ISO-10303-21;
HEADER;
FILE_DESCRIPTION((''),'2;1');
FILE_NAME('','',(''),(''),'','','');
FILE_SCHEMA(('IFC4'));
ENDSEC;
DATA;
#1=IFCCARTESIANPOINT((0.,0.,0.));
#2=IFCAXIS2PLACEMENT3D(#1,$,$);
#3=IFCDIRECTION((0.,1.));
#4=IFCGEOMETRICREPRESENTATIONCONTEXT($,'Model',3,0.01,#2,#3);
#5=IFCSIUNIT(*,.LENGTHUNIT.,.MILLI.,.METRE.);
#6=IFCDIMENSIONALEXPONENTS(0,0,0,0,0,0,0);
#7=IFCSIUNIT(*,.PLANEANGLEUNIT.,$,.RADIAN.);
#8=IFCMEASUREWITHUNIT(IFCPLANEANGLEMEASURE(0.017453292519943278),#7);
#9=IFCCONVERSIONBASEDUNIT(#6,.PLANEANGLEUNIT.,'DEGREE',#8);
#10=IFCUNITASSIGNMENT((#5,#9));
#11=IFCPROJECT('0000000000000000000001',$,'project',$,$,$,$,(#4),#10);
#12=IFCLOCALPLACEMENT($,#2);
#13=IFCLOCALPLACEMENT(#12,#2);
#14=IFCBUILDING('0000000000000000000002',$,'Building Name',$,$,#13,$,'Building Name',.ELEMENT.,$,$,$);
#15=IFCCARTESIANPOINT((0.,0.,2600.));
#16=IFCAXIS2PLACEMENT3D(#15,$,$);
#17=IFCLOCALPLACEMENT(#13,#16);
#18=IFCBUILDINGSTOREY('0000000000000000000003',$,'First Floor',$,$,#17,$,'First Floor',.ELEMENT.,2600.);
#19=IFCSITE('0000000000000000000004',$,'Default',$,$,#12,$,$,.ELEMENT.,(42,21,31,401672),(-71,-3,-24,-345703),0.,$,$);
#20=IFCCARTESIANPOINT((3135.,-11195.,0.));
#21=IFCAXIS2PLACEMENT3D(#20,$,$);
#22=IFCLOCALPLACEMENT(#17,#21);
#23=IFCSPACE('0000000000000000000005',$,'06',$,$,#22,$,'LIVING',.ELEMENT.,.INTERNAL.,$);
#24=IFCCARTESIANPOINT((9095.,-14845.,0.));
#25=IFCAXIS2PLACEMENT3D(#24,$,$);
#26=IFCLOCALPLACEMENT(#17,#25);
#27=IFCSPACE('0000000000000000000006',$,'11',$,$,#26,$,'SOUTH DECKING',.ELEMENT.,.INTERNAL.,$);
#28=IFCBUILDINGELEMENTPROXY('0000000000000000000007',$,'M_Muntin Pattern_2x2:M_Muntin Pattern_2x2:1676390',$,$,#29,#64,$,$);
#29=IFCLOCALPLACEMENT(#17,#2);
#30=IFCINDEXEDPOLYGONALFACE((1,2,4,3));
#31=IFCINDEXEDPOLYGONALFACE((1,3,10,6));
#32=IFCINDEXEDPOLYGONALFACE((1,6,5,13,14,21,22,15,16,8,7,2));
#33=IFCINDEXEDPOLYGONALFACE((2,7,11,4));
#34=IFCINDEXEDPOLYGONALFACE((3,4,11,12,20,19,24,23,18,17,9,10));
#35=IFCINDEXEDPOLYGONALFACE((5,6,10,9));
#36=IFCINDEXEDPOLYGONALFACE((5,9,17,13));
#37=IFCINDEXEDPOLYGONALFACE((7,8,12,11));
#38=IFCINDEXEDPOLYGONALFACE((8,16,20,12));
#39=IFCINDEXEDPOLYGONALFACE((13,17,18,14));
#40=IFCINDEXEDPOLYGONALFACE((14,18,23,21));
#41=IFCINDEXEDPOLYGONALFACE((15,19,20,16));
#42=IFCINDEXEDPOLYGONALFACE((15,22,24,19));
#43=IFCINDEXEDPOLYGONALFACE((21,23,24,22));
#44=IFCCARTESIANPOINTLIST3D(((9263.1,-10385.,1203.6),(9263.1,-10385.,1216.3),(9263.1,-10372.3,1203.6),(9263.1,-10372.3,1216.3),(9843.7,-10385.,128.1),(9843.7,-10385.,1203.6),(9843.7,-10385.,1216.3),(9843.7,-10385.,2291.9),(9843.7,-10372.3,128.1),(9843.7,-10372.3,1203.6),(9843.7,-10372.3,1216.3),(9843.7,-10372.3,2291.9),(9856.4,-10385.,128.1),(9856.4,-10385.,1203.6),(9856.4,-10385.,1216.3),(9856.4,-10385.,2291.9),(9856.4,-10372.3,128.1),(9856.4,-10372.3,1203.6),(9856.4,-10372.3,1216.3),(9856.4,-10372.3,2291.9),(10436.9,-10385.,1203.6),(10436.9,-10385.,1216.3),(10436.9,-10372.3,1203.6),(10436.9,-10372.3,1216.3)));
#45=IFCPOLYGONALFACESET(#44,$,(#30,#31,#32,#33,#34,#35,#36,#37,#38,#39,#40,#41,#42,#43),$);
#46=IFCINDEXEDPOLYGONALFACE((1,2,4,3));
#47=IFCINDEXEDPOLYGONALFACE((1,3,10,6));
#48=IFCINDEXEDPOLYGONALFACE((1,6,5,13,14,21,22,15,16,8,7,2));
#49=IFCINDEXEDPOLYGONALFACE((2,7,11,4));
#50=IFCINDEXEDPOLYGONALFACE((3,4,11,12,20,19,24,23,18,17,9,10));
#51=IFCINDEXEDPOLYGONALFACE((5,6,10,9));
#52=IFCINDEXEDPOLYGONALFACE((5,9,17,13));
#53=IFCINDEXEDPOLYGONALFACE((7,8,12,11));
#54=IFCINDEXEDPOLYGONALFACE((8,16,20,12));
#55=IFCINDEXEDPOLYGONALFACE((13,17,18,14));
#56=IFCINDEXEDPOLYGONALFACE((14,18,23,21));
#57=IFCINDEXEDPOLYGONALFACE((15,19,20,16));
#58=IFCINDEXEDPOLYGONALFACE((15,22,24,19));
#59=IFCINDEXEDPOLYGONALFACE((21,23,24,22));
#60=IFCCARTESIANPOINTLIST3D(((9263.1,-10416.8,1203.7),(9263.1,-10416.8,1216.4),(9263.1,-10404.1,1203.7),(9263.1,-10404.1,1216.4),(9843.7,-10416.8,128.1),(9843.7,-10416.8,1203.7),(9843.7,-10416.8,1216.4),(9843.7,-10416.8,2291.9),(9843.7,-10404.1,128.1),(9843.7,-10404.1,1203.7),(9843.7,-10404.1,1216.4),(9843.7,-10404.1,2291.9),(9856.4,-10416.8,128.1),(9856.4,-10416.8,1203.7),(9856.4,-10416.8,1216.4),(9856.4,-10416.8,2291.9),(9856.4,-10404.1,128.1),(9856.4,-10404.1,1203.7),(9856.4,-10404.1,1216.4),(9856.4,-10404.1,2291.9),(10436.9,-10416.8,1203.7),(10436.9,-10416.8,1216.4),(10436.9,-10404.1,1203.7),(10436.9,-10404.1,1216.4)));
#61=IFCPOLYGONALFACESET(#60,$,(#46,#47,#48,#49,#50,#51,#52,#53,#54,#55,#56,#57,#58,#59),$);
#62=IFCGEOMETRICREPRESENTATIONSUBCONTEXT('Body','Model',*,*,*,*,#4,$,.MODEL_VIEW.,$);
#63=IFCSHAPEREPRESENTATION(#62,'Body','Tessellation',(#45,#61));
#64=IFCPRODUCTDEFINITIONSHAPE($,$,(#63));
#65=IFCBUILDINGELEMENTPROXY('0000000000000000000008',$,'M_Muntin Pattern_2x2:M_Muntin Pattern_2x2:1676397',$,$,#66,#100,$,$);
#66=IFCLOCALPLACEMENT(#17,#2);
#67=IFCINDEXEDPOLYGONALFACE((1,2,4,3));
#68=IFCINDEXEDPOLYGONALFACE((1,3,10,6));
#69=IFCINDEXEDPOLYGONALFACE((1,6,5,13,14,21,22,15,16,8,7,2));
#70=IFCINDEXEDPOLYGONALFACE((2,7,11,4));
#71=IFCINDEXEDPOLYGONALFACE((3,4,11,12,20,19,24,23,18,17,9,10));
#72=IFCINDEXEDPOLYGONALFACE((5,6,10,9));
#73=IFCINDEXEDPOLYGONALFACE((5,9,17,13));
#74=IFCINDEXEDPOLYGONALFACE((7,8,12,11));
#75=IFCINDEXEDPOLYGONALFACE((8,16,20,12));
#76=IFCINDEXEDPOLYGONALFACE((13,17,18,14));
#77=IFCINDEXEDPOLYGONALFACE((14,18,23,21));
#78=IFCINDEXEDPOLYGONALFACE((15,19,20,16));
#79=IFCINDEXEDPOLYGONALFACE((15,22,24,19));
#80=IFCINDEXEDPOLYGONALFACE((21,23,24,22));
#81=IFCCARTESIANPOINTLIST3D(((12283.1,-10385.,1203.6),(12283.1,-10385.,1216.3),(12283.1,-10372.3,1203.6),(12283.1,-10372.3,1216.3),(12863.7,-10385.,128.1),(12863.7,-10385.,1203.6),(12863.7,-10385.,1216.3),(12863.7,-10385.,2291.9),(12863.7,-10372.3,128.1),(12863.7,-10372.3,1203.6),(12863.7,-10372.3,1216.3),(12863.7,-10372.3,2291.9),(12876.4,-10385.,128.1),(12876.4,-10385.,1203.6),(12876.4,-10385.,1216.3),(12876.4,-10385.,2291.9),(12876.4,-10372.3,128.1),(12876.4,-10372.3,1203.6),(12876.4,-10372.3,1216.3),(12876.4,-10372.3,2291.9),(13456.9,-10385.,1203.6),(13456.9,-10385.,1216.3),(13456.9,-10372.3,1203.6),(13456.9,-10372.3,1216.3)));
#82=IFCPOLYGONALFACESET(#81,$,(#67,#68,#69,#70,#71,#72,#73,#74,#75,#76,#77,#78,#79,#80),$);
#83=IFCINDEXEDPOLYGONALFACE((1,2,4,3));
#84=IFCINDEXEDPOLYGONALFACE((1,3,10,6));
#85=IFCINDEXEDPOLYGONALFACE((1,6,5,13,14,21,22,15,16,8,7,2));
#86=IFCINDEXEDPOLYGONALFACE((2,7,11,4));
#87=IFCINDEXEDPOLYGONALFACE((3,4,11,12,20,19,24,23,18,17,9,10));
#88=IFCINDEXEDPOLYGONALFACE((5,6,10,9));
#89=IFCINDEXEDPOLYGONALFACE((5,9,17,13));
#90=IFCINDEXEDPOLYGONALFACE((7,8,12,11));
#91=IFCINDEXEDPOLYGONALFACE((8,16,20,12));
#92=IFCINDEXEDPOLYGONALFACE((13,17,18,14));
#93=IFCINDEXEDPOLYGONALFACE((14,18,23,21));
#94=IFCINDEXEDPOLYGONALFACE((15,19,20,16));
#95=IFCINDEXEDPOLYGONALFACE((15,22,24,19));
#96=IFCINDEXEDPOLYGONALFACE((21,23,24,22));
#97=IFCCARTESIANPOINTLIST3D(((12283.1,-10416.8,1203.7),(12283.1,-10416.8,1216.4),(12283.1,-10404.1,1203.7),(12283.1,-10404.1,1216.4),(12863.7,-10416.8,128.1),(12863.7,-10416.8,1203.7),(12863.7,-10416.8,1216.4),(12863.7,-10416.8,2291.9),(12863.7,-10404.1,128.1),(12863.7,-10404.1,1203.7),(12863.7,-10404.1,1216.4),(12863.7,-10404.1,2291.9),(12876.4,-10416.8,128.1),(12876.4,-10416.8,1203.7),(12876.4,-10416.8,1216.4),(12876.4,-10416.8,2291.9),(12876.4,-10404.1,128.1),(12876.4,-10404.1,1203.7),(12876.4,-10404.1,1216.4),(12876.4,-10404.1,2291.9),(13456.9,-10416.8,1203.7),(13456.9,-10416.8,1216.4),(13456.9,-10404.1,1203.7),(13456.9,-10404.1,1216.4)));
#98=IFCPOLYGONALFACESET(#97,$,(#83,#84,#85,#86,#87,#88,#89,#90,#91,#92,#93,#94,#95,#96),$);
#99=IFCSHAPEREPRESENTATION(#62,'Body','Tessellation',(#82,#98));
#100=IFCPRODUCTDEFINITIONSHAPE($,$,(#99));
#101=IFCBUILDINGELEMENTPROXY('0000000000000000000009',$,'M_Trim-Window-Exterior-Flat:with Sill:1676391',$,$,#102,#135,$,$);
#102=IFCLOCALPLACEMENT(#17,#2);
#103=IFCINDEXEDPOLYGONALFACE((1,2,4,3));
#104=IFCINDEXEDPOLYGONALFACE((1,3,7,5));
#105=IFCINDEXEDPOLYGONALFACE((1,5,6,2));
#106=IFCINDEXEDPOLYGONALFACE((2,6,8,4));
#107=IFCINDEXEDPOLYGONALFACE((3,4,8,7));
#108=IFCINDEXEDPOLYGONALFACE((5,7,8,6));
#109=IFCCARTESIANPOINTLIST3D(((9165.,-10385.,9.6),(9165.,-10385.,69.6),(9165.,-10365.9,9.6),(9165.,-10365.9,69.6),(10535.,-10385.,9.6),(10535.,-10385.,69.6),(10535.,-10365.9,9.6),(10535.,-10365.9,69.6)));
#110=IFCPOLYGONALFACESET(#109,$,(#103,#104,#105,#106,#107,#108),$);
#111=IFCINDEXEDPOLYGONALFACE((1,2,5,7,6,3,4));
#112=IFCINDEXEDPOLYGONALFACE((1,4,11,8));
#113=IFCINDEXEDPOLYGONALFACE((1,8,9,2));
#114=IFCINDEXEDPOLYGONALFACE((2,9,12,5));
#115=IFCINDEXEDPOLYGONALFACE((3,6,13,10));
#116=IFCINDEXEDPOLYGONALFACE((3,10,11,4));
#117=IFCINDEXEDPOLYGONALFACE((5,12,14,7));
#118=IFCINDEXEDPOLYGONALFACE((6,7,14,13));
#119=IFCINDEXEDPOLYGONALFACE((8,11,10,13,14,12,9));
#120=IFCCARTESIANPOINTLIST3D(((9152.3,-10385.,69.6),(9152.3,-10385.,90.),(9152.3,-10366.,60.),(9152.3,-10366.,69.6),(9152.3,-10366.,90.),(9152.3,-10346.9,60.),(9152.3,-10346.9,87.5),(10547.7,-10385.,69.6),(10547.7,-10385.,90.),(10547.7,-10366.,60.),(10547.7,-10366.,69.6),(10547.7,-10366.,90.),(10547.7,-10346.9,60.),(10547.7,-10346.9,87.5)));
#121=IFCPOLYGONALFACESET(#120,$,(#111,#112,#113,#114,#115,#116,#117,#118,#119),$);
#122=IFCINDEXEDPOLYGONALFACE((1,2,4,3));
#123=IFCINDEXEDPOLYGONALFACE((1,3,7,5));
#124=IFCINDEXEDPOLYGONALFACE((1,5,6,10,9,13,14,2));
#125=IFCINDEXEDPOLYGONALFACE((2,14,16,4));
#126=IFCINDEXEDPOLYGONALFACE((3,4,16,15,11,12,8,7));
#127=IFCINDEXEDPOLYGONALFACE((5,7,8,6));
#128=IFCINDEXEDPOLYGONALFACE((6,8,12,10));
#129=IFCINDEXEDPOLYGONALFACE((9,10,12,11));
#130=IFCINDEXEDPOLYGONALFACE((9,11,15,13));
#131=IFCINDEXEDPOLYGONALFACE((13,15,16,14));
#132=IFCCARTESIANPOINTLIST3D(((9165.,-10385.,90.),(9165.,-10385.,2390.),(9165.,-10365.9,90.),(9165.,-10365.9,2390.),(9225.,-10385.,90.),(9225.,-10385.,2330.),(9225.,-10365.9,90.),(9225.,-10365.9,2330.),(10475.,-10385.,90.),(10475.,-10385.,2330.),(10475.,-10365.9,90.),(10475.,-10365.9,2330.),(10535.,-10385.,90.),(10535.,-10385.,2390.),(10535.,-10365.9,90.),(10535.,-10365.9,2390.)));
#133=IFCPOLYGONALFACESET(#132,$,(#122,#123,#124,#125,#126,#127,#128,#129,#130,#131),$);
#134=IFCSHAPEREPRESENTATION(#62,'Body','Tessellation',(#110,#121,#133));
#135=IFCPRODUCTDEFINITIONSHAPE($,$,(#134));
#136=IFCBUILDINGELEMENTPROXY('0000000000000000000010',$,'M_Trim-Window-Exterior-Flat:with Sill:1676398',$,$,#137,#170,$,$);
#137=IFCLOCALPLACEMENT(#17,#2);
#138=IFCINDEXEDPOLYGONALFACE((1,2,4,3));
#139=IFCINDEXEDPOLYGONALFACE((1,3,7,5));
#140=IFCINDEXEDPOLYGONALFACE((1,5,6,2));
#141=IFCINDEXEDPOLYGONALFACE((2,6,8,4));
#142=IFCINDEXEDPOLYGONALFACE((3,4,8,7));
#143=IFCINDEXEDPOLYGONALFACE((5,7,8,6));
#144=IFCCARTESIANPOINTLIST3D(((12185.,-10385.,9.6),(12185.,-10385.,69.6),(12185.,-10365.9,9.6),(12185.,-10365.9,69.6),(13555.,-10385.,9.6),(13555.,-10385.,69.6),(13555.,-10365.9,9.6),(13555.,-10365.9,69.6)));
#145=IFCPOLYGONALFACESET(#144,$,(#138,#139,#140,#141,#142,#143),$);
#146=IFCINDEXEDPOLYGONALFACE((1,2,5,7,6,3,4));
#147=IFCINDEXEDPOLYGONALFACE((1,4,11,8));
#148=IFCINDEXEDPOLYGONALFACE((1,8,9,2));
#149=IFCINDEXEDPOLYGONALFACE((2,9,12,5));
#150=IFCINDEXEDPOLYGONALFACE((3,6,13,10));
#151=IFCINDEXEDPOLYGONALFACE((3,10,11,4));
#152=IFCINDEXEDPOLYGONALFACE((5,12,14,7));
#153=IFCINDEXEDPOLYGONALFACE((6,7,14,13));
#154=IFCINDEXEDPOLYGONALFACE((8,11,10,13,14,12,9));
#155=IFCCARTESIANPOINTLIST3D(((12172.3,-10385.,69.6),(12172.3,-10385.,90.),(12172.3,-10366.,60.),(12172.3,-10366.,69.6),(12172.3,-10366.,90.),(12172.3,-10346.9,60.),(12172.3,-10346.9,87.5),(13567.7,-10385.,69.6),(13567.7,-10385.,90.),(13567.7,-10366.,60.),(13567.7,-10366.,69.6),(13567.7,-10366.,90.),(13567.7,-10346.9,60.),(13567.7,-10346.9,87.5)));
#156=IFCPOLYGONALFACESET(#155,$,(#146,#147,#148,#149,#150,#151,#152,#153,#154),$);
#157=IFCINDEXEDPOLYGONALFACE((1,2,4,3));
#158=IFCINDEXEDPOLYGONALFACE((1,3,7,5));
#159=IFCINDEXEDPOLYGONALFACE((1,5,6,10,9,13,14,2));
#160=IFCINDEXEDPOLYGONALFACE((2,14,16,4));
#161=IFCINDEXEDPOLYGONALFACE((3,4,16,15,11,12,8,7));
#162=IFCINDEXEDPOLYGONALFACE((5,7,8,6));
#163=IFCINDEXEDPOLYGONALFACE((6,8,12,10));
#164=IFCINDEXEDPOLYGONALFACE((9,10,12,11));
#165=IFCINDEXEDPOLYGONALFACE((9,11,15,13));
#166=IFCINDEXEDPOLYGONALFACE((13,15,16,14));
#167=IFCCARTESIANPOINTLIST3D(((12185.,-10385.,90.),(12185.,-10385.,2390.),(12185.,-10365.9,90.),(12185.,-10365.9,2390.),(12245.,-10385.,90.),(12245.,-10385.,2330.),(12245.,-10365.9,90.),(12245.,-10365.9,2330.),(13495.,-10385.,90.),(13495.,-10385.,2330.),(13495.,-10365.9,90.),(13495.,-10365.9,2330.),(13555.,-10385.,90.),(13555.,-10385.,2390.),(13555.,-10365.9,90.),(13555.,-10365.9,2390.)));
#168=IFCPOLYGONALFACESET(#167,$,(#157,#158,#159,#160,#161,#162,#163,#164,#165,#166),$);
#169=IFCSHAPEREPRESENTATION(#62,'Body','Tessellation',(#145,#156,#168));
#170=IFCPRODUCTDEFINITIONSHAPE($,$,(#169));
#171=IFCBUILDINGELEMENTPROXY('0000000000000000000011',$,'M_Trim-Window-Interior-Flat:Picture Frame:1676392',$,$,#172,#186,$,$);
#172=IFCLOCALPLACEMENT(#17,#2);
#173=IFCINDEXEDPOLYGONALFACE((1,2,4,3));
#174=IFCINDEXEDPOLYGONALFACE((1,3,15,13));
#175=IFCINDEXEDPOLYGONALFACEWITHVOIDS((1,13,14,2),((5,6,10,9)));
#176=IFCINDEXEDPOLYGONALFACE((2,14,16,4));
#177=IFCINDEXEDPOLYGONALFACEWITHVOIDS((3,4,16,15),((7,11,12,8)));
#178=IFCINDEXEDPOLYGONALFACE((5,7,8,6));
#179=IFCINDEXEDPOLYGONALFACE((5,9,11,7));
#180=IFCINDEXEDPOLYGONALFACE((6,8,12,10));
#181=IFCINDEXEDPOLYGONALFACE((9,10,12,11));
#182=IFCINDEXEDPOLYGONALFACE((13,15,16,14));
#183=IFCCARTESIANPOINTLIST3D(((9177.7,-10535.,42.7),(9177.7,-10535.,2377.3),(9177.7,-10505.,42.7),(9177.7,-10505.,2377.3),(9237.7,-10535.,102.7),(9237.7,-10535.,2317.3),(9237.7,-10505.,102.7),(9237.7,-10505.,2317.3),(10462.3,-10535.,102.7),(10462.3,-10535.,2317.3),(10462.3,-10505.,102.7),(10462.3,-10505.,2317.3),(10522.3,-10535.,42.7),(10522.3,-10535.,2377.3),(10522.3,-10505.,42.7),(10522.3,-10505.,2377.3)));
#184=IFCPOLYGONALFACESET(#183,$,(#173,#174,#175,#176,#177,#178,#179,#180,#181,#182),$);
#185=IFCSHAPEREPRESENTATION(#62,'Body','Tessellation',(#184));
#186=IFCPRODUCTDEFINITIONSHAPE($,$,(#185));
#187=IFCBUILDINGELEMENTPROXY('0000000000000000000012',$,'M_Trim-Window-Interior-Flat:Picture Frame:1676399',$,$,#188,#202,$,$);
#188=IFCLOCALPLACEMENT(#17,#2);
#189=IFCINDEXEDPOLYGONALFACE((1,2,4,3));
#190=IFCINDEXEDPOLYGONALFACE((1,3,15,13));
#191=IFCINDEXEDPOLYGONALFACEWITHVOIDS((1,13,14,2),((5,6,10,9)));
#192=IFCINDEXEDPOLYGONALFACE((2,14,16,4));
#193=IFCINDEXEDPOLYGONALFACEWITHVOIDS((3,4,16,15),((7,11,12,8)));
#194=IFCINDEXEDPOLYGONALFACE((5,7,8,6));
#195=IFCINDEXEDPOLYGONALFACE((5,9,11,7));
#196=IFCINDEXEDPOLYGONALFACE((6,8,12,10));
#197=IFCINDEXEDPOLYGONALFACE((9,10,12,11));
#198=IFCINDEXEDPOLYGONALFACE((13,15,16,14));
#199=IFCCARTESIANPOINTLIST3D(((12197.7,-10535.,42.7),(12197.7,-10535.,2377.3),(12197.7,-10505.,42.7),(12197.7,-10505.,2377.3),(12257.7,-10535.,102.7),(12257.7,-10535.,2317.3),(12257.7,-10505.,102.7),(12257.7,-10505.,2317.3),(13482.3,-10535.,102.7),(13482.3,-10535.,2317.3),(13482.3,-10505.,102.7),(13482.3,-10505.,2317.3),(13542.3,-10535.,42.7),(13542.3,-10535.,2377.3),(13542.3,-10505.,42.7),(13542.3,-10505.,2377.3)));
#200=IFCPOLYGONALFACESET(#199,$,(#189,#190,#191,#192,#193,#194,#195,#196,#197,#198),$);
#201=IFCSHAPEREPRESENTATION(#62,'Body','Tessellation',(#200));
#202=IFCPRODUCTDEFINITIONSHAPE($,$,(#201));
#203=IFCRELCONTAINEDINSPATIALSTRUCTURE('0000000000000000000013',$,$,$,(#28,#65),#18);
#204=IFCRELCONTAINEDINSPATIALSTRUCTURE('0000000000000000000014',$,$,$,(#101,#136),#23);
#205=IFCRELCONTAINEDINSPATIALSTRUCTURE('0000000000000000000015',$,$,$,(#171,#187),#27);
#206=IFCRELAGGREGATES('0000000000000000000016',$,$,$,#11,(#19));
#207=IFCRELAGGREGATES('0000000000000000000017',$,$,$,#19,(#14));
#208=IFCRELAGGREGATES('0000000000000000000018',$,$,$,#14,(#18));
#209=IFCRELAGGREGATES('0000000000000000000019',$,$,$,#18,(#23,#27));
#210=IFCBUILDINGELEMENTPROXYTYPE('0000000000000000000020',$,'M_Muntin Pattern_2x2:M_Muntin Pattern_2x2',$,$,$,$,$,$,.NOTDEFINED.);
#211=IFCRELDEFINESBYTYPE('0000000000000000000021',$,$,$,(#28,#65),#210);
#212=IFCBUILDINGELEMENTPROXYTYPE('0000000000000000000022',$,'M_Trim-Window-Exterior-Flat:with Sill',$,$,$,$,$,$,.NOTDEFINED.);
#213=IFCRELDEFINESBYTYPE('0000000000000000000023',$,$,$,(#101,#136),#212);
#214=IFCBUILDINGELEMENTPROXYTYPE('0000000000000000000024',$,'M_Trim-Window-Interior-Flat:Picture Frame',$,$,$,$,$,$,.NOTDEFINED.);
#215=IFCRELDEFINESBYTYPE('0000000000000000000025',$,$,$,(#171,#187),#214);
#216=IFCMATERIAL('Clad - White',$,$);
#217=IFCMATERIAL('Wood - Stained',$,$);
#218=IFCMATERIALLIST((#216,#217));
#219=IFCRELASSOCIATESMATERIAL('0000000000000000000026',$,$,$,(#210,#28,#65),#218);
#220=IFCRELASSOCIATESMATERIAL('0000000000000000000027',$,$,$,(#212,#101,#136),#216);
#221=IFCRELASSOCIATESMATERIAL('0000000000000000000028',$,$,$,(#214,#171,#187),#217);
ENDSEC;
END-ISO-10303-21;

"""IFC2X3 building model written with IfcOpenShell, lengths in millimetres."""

from ifc_helpers import new_model, entity, si_unit, converted_unit, direction, frame, frame_2d, origin, place, context, subcontext, project, spatial, polyline, rectangle, outline, extrude, source, transform, mapped, material, material_list, type_object, type_shapes, element, save


model = new_model("IFC2X3")

# Units and contexts
model_context = context("Model", 3, precision=0.01, world=origin(), true_north=direction((0.0, 1.0)))
body_context = subcontext(model_context, "Body", "Model", "MODEL_VIEW")
ifc_project = project(units=[si_unit("LENGTHUNIT", "METRE", prefix="MILLI"), converted_unit("PLANEANGLEUNIT", "DEGREE", entity("IfcPlaneAngleMeasure", 0.017453292519943278), si_unit("PLANEANGLEUNIT", "RADIAN"), dimensions=[0, 0, 0, 0, 0, 0, 0])], contexts=[model_context])

# Site, building, storey
site_placement = place(None, origin())
site = spatial("IfcSite", under=ifc_project, at=site_placement, Name="Default", CompositionType="ELEMENT", RefLatitude=(42, 21, 31, 401672), RefLongitude=(-71, -3, -24, -345703), RefElevation=0.0)
building_placement = place(site_placement, origin())
building = spatial("IfcBuilding", under=site, at=building_placement, Name="Building Name", LongName="Building Name", CompositionType="ELEMENT")
storey_placement = place(building_placement, frame((0.0, 0.0, 2600.0)))
storey = spatial("IfcBuildingStorey", under=building, at=storey_placement, Name="First Floor", LongName="First Floor", CompositionType="ELEMENT", Elevation=2600.0)

# Shared definitions
space_1_placement = place(storey_placement, frame((3135.0, -11195.0, 0.0)))
space_1 = spatial("IfcSpace", under=storey, at=space_1_placement, Name="06", LongName="LIVING", CompositionType="ELEMENT", InteriorOrExteriorSpace="INTERNAL")

# Shared definitions
ifc_material_1 = material(Name="Clad - White")
ifc_material_2 = material(Name="Wood - Stained")
ifc_material_list_1 = material_list([ifc_material_1, ifc_material_2])

# Building element proxies
building_element_proxy_type_1 = type_object("IfcBuildingElementProxyType", Name="M_Muntin Pattern_2x2:M_Muntin Pattern_2x2", PredefinedType="NOTDEFINED", material=ifc_material_list_1)
shared_shape_1 = source(origin(), body_context, "Body", "SweptSolid", [
    extrude(outline(polyline([(6.4, -6.4), (1081.9, -6.4), (1081.9, 6.3), (6.4, 6.3), (6.4, 586.9), (-6.3, 586.9), (-6.3, 6.3), (-1081.9, 6.3), (-1081.9, -6.4), (-6.3, -6.4), (-6.3, -586.9), (6.4, -586.9), (6.4, -6.4)])), frame((0.0, -22.2, 1081.9), z_axis=(0.0, 1.0, 0.0), x_axis=(0.0, 0.0, 1.0)), (0.0, 0.0, 1.0), 12.7),
    extrude(outline(polyline([(6.4, -6.4), (1081.9, -6.4), (1081.9, 6.3), (6.4, 6.3), (6.4, 586.9), (-6.3, 586.9), (-6.3, 6.3), (-1081.9, 6.3), (-1081.9, -6.4), (-6.3, -6.4), (-6.3, -586.9), (6.4, -586.9), (6.4, -6.4)])), frame((0.0, 9.5, 1081.9), z_axis=(0.0, 1.0, 0.0), x_axis=(0.0, 0.0, 1.0)), (0.0, 0.0, 1.0), 12.7),
])
type_shapes(building_element_proxy_type_1, [shared_shape_1])
for number, where, z_axis, x_axis, name in (
    (1, (9850.0, -10394.5, 128.1), (0.0, 0.0, 1.0), (-1.0, 0.0, 0.0), "M_Muntin Pattern_2x2:M_Muntin Pattern_2x2:1676390"),
    (2, (12870.0, -10394.5, 128.1), (0.0, 0.0, 1.0), (-1.0, 0.0, 0.0), "M_Muntin Pattern_2x2:M_Muntin Pattern_2x2:1676397"),
):
    element("IfcBuildingElementProxy", number, at=place(storey_placement, frame(where, z_axis=z_axis, x_axis=x_axis)), inside=storey, type_object=building_element_proxy_type_1, material=ifc_material_list_1, Name=name, context=body_context, shape_type="MappedRepresentation", body=[
        mapped(shared_shape_1, transform((0.0, 0.0, 0.0), scale=1.0)),
    ])
building_element_proxy_type_2 = type_object("IfcBuildingElementProxyType", Name="M_Trim-Window-Exterior-Flat:with Sill", PredefinedType="NOTDEFINED", material=ifc_material_1)
shared_shape_2 = source(origin(), body_context, "Body", "SweptSolid", [
    extrude(rectangle(XDim=1370.0, YDim=60.0, at=frame_2d((0.0, 0.0), x_axis=(1.0, 0.0))), frame((0.0, -2290.4, 0.0), z_axis=(0.0, 0.0, 1.0), x_axis=(-1.0, 0.0, 0.0)), (0.0, 0.0, 1.0), 19.0),
    extrude(outline(polyline([(-19.0, -15.2), (0.0, -15.2), (0.0, -5.7), (19.0, -5.7), (19.0, 14.8), (0.0, 14.8), (-19.0, 12.3), (-19.0, -15.2)])), frame((-697.7, -2254.8, 19.0), z_axis=(1.0, 0.0, 0.0), x_axis=(0.0, 0.0, -1.0)), (0.0, 0.0, 1.0), 1395.4),
    extrude(outline(polyline([(-1165.0, -685.0), (1135.0, -685.0), (1135.0, -625.0), (-1105.0, -625.0), (-1105.0, 625.0), (1135.0, 625.0), (1135.0, 685.0), (-1165.0, 685.0), (-1165.0, -685.0)])), frame((0.0, -1105.0, 0.0), z_axis=(0.0, 0.0, 1.0), x_axis=(0.0, -1.0, 0.0)), (0.0, 0.0, 1.0), 19.0),
])
type_shapes(building_element_proxy_type_2, [shared_shape_2])
for number, where, z_axis, x_axis, name in (
    (3, (6715.0, 810.0, 2330.0), (0.0, 1.0, 0.0), (-1.0, 0.0, 0.0), "M_Trim-Window-Exterior-Flat:with Sill:1676391"),
    (4, (9735.0, 810.0, 2330.0), (0.0, 1.0, 0.0), (-1.0, 0.0, 0.0), "M_Trim-Window-Exterior-Flat:with Sill:1676398"),
):
    element("IfcBuildingElementProxy", number, at=place(space_1_placement, frame(where, z_axis=z_axis, x_axis=x_axis)), inside=space_1, type_object=building_element_proxy_type_2, material=ifc_material_1, Name=name, context=body_context, shape_type="MappedRepresentation", body=[
        mapped(shared_shape_2, transform((0.0, 0.0, 0.0), scale=1.0)),
    ])

# Shared definitions
space_2_placement = place(storey_placement, frame((9095.0, -14845.0, 0.0)))
space_2 = spatial("IfcSpace", under=storey, at=space_2_placement, Name="11", LongName="SOUTH DECKING", CompositionType="ELEMENT", InteriorOrExteriorSpace="INTERNAL")

# Building element proxies
building_element_proxy_type_3 = type_object("IfcBuildingElementProxyType", Name="M_Trim-Window-Interior-Flat:Picture Frame", PredefinedType="NOTDEFINED", material=ifc_material_2)
shared_shape_3 = source(origin(), body_context, "Body", "SweptSolid", [
    extrude(outline(polyline([(-672.3, -1167.3), (672.3, -1167.3), (672.3, 1167.3), (-672.3, 1167.3), (-672.3, -1167.3)]), holes=[polyline([(-612.3, -1107.3), (-612.3, 1107.3), (612.3, 1107.3), (612.3, -1107.3), (-612.3, -1107.3)])]), frame((0.0, -1120.0, 0.0), z_axis=(0.0, 0.0, 1.0), x_axis=(-1.0, 0.0, 0.0)), (0.0, 0.0, 1.0), 30.0),
])
type_shapes(building_element_proxy_type_3, [shared_shape_3])
for number, where, z_axis, x_axis, name in (
    (5, (755.0, 4340.0, 2330.0), (0.0, -1.0, 0.0), (1.0, 0.0, 0.0), "M_Trim-Window-Interior-Flat:Picture Frame:1676392"),
    (6, (3775.0, 4340.0, 2330.0), (0.0, -1.0, 0.0), (1.0, 0.0, 0.0), "M_Trim-Window-Interior-Flat:Picture Frame:1676399"),
):
    element("IfcBuildingElementProxy", number, at=place(space_2_placement, frame(where, z_axis=z_axis, x_axis=x_axis)), inside=space_2, type_object=building_element_proxy_type_3, material=ifc_material_2, Name=name, context=body_context, shape_type="MappedRepresentation", body=[
        mapped(shared_shape_3, transform((0.0, 0.0, 0.0), scale=1.0)),
    ])

save(model, "model.ifc")
